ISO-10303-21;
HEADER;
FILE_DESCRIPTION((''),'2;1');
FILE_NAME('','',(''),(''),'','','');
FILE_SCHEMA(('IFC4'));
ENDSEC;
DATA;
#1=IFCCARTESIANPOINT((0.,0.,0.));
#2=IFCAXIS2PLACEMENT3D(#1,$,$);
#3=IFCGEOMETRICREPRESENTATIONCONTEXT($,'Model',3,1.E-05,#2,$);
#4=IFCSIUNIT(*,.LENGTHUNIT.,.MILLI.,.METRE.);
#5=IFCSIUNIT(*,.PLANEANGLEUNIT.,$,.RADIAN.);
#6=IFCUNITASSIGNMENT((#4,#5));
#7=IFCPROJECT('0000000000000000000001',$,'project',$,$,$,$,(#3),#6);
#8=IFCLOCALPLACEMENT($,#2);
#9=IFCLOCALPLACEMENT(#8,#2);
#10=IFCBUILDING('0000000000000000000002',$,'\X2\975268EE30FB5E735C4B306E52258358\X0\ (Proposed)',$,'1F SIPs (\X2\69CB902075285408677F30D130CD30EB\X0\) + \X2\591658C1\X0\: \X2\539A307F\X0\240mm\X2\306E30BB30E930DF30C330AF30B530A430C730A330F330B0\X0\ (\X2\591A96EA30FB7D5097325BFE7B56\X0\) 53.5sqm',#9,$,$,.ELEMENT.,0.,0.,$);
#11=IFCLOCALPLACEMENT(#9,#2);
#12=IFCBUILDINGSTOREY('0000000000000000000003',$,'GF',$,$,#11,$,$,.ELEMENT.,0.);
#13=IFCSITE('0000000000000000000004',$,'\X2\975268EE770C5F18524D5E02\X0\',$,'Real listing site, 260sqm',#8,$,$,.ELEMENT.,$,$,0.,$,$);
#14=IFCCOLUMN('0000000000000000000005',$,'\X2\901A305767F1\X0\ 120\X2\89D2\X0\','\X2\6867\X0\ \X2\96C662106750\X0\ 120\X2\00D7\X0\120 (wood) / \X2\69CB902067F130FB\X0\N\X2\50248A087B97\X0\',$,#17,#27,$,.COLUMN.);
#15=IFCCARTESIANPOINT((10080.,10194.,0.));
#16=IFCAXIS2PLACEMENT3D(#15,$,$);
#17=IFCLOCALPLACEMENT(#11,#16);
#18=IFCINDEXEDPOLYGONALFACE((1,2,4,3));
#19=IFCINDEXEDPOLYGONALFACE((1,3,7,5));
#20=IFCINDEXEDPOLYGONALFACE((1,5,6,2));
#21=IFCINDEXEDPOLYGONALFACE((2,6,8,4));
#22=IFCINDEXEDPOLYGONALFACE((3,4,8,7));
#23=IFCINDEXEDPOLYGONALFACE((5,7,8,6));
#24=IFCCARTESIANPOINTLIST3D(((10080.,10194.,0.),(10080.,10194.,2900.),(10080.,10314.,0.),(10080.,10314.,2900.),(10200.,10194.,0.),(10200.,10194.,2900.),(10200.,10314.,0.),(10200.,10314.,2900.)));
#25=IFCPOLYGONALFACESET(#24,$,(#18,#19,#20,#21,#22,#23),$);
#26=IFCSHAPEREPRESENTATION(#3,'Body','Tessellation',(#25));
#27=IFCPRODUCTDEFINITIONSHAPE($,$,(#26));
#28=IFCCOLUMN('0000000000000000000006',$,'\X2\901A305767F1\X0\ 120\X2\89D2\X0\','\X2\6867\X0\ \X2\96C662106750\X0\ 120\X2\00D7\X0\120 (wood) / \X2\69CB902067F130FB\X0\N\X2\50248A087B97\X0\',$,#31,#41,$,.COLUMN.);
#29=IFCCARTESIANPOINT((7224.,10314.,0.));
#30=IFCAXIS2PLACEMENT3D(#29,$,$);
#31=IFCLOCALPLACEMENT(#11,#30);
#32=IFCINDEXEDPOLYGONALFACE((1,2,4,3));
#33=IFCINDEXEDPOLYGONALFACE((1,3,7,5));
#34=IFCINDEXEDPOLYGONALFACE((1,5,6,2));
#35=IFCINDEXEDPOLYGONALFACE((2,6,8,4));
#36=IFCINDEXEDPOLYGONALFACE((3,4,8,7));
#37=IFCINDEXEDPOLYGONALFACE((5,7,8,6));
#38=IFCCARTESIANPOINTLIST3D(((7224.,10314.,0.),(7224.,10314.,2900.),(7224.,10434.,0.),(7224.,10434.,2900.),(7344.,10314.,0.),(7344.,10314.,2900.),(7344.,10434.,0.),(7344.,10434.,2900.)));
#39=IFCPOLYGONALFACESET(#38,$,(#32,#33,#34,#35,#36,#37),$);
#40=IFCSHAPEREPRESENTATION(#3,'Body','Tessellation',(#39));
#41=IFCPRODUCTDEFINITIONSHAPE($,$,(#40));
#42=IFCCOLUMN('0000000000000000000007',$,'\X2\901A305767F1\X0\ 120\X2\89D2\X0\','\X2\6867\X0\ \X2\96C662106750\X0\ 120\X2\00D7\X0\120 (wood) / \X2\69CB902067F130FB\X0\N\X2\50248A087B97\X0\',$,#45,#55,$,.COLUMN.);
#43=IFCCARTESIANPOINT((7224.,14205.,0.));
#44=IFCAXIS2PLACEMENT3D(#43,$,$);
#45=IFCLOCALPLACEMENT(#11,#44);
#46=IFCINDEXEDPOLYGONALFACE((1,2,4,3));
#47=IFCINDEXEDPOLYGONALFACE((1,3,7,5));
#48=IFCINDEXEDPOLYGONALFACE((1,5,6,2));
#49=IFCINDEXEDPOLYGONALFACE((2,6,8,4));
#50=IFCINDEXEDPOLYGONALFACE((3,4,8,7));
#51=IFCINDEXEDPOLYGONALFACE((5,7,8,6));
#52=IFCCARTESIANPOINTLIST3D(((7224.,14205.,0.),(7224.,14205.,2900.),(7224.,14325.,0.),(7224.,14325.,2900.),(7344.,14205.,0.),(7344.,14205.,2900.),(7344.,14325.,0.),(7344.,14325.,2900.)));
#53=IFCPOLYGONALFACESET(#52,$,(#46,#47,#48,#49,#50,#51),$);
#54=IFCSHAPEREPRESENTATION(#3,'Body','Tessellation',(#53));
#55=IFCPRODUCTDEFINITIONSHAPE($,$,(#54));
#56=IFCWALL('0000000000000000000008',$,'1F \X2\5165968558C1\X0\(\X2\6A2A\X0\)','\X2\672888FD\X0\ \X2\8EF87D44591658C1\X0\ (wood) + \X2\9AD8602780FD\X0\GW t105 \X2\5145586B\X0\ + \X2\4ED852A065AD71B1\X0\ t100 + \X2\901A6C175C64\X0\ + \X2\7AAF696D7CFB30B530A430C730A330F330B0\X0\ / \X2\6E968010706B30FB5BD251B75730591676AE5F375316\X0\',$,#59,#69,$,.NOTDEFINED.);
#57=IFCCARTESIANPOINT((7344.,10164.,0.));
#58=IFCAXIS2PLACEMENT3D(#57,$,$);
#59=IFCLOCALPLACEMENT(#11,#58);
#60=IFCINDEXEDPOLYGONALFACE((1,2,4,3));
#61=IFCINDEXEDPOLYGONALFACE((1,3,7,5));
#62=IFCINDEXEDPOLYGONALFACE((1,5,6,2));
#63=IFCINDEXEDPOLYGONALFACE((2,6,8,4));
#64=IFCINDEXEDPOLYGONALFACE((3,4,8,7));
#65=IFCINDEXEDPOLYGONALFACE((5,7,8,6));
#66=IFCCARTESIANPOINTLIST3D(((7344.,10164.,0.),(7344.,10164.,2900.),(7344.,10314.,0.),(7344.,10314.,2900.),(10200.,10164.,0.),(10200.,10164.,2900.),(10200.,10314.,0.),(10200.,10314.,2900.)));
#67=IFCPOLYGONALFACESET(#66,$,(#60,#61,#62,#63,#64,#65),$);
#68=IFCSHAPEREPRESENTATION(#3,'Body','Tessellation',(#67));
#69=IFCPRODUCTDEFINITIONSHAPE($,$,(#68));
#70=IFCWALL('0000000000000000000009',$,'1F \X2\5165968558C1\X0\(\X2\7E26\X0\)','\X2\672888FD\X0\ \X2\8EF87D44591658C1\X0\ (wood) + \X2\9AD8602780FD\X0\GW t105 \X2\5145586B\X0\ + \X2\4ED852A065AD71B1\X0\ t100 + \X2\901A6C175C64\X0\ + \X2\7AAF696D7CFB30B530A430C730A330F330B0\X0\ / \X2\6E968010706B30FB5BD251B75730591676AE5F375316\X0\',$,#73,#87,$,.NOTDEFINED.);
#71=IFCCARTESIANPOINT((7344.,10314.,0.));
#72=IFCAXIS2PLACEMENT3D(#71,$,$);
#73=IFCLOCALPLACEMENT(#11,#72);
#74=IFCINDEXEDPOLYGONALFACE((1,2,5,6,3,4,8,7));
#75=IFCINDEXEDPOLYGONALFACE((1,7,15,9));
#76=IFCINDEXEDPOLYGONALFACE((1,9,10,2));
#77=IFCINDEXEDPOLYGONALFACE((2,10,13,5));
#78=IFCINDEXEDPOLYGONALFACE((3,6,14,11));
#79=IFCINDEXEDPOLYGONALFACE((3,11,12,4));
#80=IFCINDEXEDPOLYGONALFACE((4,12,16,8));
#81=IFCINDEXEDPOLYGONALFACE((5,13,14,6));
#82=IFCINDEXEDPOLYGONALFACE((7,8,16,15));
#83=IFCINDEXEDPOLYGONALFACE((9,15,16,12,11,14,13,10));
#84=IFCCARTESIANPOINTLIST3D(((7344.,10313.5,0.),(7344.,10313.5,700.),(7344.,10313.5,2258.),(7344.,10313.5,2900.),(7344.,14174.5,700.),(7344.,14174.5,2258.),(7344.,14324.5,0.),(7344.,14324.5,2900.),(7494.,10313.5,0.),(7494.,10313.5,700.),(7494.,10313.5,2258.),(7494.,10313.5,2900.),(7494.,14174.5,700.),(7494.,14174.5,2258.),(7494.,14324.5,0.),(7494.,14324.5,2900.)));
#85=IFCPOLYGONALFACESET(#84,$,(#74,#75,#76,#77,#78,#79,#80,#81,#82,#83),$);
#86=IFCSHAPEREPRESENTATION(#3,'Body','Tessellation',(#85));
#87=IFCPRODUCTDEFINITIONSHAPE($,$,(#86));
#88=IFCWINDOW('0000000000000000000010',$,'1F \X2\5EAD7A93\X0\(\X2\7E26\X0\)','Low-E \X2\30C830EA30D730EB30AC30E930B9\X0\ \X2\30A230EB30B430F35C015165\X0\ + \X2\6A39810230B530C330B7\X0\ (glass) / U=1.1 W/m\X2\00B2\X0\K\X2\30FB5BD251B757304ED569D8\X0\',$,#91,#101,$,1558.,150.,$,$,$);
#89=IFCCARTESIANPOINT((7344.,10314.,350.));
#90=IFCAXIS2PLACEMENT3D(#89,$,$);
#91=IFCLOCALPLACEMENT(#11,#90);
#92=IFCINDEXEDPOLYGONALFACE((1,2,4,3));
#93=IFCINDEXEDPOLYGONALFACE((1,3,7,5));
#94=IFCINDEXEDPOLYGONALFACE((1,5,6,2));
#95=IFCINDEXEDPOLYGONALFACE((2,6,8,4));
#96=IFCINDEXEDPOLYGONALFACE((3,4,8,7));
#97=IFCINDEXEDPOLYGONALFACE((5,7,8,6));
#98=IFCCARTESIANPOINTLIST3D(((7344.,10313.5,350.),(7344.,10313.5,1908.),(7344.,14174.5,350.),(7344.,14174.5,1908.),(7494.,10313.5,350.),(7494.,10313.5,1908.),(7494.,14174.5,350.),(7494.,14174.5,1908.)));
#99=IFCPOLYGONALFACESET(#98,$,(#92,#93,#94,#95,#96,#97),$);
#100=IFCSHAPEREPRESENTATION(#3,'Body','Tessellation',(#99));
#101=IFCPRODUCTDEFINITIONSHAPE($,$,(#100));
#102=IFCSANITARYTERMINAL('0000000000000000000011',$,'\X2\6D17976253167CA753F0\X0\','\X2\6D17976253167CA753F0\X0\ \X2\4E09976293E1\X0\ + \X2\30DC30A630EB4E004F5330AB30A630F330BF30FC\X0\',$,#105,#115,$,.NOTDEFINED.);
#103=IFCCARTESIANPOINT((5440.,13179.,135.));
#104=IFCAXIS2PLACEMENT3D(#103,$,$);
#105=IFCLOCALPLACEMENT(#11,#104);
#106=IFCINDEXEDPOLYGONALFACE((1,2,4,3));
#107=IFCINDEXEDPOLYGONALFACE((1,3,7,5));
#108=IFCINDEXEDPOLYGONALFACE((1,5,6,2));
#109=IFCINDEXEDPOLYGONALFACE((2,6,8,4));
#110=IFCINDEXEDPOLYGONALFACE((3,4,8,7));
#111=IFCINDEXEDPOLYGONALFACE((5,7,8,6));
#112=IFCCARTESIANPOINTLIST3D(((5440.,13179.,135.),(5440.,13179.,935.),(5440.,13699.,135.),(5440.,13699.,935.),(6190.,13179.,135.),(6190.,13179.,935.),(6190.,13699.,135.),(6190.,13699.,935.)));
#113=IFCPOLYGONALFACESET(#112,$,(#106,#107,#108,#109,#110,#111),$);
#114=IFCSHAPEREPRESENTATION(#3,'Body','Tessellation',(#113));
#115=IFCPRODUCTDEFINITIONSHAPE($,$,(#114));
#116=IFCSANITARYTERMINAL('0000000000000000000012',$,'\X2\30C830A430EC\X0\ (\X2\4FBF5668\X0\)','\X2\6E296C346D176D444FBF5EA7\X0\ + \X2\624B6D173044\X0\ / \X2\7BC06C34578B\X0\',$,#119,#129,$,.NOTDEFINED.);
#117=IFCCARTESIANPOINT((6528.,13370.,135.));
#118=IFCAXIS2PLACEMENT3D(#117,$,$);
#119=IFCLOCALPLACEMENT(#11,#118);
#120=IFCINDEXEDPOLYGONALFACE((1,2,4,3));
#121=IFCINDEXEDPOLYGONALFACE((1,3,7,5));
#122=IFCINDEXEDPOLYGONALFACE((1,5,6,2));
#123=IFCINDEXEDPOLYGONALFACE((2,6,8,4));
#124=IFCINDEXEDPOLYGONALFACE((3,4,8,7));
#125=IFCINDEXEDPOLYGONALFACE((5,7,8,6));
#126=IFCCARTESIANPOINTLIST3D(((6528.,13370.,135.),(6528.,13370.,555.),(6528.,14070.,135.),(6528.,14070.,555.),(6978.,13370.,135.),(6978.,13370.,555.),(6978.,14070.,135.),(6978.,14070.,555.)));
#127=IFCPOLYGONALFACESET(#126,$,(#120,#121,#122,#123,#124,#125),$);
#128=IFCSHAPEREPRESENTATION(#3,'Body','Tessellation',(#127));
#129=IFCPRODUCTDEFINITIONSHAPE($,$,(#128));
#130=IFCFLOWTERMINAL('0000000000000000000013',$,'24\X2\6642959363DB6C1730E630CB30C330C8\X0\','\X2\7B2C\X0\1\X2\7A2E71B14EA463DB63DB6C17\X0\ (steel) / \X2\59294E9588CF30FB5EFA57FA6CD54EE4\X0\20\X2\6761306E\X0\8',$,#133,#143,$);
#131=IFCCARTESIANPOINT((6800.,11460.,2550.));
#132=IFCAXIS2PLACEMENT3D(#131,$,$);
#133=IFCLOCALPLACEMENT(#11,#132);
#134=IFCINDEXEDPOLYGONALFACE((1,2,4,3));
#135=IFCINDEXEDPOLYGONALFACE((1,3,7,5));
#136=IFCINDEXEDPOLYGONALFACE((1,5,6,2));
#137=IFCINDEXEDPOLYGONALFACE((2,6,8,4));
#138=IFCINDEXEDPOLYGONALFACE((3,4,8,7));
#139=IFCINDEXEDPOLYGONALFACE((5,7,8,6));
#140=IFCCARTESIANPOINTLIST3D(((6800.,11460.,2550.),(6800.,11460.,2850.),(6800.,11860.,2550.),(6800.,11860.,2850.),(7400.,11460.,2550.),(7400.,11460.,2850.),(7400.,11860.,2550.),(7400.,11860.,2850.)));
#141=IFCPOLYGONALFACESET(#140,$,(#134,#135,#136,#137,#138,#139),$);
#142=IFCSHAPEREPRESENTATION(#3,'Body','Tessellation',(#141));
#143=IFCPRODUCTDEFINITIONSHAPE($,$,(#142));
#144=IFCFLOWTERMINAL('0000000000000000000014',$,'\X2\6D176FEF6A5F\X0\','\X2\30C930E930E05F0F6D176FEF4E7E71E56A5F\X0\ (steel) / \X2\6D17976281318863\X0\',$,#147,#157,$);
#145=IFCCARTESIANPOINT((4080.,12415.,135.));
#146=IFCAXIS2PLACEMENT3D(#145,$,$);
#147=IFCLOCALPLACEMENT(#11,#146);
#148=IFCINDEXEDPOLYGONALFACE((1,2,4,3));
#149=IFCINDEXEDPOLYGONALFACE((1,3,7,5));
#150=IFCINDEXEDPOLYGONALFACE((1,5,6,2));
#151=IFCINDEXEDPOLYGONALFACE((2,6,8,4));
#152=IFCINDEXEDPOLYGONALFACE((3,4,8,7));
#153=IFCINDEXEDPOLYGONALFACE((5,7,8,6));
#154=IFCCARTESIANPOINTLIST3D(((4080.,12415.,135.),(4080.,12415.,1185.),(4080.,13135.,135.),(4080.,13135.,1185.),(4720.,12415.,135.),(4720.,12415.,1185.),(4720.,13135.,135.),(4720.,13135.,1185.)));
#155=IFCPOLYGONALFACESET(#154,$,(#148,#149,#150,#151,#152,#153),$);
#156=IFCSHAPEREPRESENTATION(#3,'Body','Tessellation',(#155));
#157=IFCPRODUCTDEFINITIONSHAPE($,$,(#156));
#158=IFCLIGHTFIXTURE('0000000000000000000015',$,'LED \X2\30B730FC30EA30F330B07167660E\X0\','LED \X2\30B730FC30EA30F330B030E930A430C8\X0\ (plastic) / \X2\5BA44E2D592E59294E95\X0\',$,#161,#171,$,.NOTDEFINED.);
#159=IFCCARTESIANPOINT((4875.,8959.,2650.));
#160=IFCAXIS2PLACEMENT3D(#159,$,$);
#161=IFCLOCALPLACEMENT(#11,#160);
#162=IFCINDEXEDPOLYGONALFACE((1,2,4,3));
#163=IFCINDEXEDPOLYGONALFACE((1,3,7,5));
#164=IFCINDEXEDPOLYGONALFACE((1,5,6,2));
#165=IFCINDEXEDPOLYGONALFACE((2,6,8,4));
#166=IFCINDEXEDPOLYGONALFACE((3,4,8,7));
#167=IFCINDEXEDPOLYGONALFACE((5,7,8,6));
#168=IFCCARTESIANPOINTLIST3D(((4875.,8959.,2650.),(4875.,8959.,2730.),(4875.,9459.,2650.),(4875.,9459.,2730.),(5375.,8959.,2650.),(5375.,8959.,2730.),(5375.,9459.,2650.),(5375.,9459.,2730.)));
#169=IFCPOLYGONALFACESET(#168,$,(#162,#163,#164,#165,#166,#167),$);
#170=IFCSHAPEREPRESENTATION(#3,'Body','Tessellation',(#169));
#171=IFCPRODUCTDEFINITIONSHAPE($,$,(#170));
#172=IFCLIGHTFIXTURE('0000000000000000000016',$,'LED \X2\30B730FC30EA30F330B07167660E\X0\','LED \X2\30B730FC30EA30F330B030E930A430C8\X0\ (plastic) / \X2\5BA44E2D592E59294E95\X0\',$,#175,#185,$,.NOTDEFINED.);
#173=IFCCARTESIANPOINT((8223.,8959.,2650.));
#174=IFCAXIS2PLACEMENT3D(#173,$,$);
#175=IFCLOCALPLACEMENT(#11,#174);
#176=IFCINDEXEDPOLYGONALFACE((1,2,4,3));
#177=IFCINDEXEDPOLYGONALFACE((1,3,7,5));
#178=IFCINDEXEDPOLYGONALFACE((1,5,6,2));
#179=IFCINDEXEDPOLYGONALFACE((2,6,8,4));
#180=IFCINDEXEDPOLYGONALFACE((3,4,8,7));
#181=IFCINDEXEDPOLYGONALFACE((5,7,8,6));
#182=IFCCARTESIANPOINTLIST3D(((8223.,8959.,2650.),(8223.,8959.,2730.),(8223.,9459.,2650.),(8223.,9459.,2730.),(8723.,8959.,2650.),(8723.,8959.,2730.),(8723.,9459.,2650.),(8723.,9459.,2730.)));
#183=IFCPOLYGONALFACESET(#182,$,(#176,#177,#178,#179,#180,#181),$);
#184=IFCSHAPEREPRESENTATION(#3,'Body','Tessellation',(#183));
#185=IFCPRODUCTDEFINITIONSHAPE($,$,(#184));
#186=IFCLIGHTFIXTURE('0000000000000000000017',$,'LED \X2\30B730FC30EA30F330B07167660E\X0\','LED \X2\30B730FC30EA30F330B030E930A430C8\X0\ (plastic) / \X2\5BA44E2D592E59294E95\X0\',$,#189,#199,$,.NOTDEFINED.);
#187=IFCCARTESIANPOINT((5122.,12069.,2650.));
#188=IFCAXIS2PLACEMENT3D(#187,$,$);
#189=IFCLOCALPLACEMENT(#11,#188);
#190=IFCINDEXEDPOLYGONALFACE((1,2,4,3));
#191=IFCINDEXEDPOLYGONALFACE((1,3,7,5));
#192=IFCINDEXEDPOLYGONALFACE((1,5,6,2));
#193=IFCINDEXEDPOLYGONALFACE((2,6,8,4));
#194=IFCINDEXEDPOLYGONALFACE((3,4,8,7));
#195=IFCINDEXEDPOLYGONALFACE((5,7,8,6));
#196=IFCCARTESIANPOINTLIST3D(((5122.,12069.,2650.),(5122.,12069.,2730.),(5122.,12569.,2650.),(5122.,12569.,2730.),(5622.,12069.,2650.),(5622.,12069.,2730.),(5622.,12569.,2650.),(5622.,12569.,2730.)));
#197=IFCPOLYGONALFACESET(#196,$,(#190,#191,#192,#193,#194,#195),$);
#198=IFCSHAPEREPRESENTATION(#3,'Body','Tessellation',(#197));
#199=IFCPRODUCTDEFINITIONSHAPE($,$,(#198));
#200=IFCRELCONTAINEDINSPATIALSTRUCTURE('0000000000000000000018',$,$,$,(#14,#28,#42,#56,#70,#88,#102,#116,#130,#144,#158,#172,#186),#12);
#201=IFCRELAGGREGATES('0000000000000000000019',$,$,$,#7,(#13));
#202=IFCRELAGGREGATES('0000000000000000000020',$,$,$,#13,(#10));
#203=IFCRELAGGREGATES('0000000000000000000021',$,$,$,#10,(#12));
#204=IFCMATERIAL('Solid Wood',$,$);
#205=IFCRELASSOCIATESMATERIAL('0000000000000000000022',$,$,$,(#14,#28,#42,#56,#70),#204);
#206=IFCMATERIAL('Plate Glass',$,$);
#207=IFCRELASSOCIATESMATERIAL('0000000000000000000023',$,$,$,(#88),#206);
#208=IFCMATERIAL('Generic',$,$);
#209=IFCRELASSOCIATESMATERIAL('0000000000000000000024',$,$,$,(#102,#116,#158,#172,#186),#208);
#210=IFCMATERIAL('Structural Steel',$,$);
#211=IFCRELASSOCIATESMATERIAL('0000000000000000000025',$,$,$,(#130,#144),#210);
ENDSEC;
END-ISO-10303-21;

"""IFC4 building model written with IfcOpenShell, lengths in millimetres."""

from ifc_helpers import new_model, si_unit, frame, frame_2d, origin, place, context, project, spatial, rectangle, extrude, material, element, fill, save


model = new_model("IFC4")

# Units and contexts
model_context = context("Model", 3, precision=1e-05, world=origin())
ifc_project = project(units=[si_unit("LENGTHUNIT", "METRE", prefix="MILLI"), si_unit("PLANEANGLEUNIT", "RADIAN")], contexts=[model_context])

# Site, building, storey
site_placement = place(None, origin())
site = spatial("IfcSite", under=ifc_project, at=site_placement, Name="青森県弘前市", ObjectType="Real listing site, 260sqm", CompositionType="ELEMENT", RefElevation=0.0)
building_placement = place(site_placement, origin())
building = spatial("IfcBuilding", under=site, at=building_placement, Name="青森・平屋の別荘 (Proposed)", ObjectType="1F SIPs (構造用合板パネル) + 外壁: 厚み240mmのセラミックサイディング (多雪・結露対策) 53.5sqm", CompositionType="ELEMENT", ElevationOfRefHeight=0.0, ElevationOfTerrain=0.0)
storey_placement = place(building_placement, origin())
storey = spatial("IfcBuildingStorey", under=building, at=storey_placement, Name="GF", CompositionType="ELEMENT", Elevation=0.0)

# Columns
ifc_material_1 = material(Name="Solid Wood")
column_1_placement = place(storey_placement, frame((10080.0, 10194.0, 0.0)))
element("IfcColumn", 1, at=column_1_placement, inside=storey, material=ifc_material_1, Name="通し柱 120角", Description="桧 集成材 120×120 (wood) / 構造柱・N値計算", PredefinedType="COLUMN", context=model_context, shape_type="SweptSolid", body=[
    extrude(rectangle(XDim=120.0, YDim=120.0, at=frame_2d((60.0, 60.0))), frame((10080.0, 10194.0, 0.0)), (0.0, 0.0, 1.0), 2900.0),
])
column_2_placement = place(storey_placement, frame((7224.0, 10314.0, 0.0)))
element("IfcColumn", 2, at=column_2_placement, inside=storey, material=ifc_material_1, Name="通し柱 120角", Description="桧 集成材 120×120 (wood) / 構造柱・N値計算", PredefinedType="COLUMN", context=model_context, shape_type="SweptSolid", body=[
    extrude(rectangle(XDim=120.0, YDim=120.0, at=frame_2d((60.0, 60.0))), frame((7224.0, 10314.0, 0.0)), (0.0, 0.0, 1.0), 2900.0),
])
column_3_placement = place(storey_placement, frame((7224.0, 14205.0, 0.0)))
element("IfcColumn", 3, at=column_3_placement, inside=storey, material=ifc_material_1, Name="通し柱 120角", Description="桧 集成材 120×120 (wood) / 構造柱・N値計算", PredefinedType="COLUMN", context=model_context, shape_type="SweptSolid", body=[
    extrude(rectangle(XDim=120.0, YDim=120.0, at=frame_2d((60.0, 60.0))), frame((7224.0, 14205.0, 0.0)), (0.0, 0.0, 1.0), 2900.0),
])

# Wall
wall_1_placement = place(storey_placement, frame((7344.0, 10164.0, 0.0)))
element("IfcWall", 4, at=wall_1_placement, inside=storey, material=ifc_material_1, Name="1F 入隅壁(横)", Description="木製 軸組外壁 (wood) + 高性能GW t105 充填 + 付加断熱 t100 + 通気層 + 窯業系サイディング / 準耐火・寒冷地外皮強化", PredefinedType="NOTDEFINED", context=model_context, shape_type="SweptSolid", body=[
    extrude(rectangle(XDim=2856.0, YDim=150.0, at=frame_2d((1428.0, 75.0))), frame((7344.0, 10164.0, 0.0)), (0.0, 0.0, 1.0), 2900.0),
])

# Wall, opening, window
wall_2_placement = place(storey_placement, frame((7344.0, 10314.0, 0.0)))
wall_2 = element("IfcWall", 5, at=wall_2_placement, inside=storey, material=ifc_material_1, Name="1F 入隅壁(縦)", Description="木製 軸組外壁 (wood) + 高性能GW t105 充填 + 付加断熱 t100 + 通気層 + 窯業系サイディング / 準耐火・寒冷地外皮強化", PredefinedType="NOTDEFINED", context=model_context, shape_type="SweptSolid", body=[
    extrude(rectangle(XDim=150.0, YDim=4011.0, at=frame_2d((75.0, 2005.0))), frame((7344.0, 10314.0, 0.0)), (0.0, 0.0, 1.0), 2900.0),
])
opening_placement = place(storey_placement, frame((7344.0, 10314.0, 350.0)))
opening = element("IfcOpeningElement", 6, at=opening_placement, cuts=wall_2, PredefinedType="NOTDEFINED", context=model_context, shape_type="SweptSolid", body=[
    extrude(rectangle(XDim=150.0, YDim=3861.0, at=frame_2d((75.0, 1930.0))), frame((7344.0, 10314.0, 350.0)), (0.0, 0.0, 1.0), 1558.0),
])
ifc_material_2 = material(Name="Plate Glass")
window_placement = place(storey_placement, frame((7344.0, 10314.0, 350.0)))
window = element("IfcWindow", 7, at=window_placement, inside=storey, material=ifc_material_2, Name="1F 庭窓(縦)", Description="Low-E トリプルガラス アルゴン封入 + 樹脂サッシ (glass) / U=1.1 W/m²K・寒冷地仕様", OverallHeight=1558.0, OverallWidth=150.0, context=model_context, shape_type="SweptSolid", body=[
    extrude(rectangle(XDim=150.0, YDim=3861.0, at=frame_2d((75.0, 1930.0))), frame((7344.0, 10314.0, 350.0)), (0.0, 0.0, 1.0), 1558.0),
])
fill(opening, window)

# Sanitary terminals
ifc_material_3 = material(Name="Generic")
sanitary_terminal_1_placement = place(storey_placement, frame((5440.0, 13179.0, 135.0)))
element("IfcSanitaryTerminal", 8, at=sanitary_terminal_1_placement, inside=storey, material=ifc_material_3, Name="洗面化粧台", Description="洗面化粧台 三面鏡 + ボウル一体カウンター", PredefinedType="NOTDEFINED", context=model_context, shape_type="SweptSolid", body=[
    extrude(rectangle(XDim=750.0, YDim=520.0, at=frame_2d((375.0, 260.0))), frame((5440.0, 13179.0, 135.0)), (0.0, 0.0, 1.0), 800.0),
])
sanitary_terminal_2_placement = place(storey_placement, frame((6528.0, 13370.0, 135.0)))
element("IfcSanitaryTerminal", 9, at=sanitary_terminal_2_placement, inside=storey, material=ifc_material_3, Name="トイレ (便器)", Description="温水洗浄便座 + 手洗い / 節水型", PredefinedType="NOTDEFINED", context=model_context, shape_type="SweptSolid", body=[
    extrude(rectangle(XDim=450.0, YDim=700.0, at=frame_2d((225.0, 350.0))), frame((6528.0, 13370.0, 135.0)), (0.0, 0.0, 1.0), 420.0),
])

# Flow terminals
ifc_material_4 = material(Name="Structural Steel")
flow_terminal_1_placement = place(storey_placement, frame((6800.0, 11460.0, 2550.0)))
element("IfcFlowTerminal", 10, at=flow_terminal_1_placement, inside=storey, material=ifc_material_4, Name="24時間換気ユニット", Description="第1種熱交換換気 (steel) / 天井裏・建基法令20条の8", context=model_context, shape_type="SweptSolid", body=[
    extrude(rectangle(XDim=600.0, YDim=400.0, at=frame_2d((300.0, 200.0))), frame((6800.0, 11460.0, 2550.0)), (0.0, 0.0, 1.0), 300.0),
])
flow_terminal_2_placement = place(storey_placement, frame((4080.0, 12415.0, 135.0)))
element("IfcFlowTerminal", 11, at=flow_terminal_2_placement, inside=storey, material=ifc_material_4, Name="洗濯機", Description="ドラム式洗濯乾燥機 (steel) / 洗面脱衣", context=model_context, shape_type="SweptSolid", body=[
    extrude(rectangle(XDim=640.0, YDim=720.0, at=frame_2d((320.0, 360.0))), frame((4080.0, 12415.0, 135.0)), (0.0, 0.0, 1.0), 1050.0),
])

# Light fixtures
light_fixture_1_placement = place(storey_placement, frame((4875.0, 8959.0, 2650.0)))
element("IfcLightFixture", 12, at=light_fixture_1_placement, inside=storey, material=ifc_material_3, Name="LED シーリング照明", Description="LED シーリングライト (plastic) / 室中央天井", PredefinedType="NOTDEFINED", context=model_context, shape_type="SweptSolid", body=[
    extrude(rectangle(XDim=500.0, YDim=500.0, at=frame_2d((250.0, 250.0))), frame((4875.0, 8959.0, 2650.0)), (0.0, 0.0, 1.0), 80.0),
])
light_fixture_2_placement = place(storey_placement, frame((8223.0, 8959.0, 2650.0)))
element("IfcLightFixture", 13, at=light_fixture_2_placement, inside=storey, material=ifc_material_3, Name="LED シーリング照明", Description="LED シーリングライト (plastic) / 室中央天井", PredefinedType="NOTDEFINED", context=model_context, shape_type="SweptSolid", body=[
    extrude(rectangle(XDim=500.0, YDim=500.0, at=frame_2d((250.0, 250.0))), frame((8223.0, 8959.0, 2650.0)), (0.0, 0.0, 1.0), 80.0),
])
light_fixture_3_placement = place(storey_placement, frame((5122.0, 12069.0, 2650.0)))
element("IfcLightFixture", 14, at=light_fixture_3_placement, inside=storey, material=ifc_material_3, Name="LED シーリング照明", Description="LED シーリングライト (plastic) / 室中央天井", PredefinedType="NOTDEFINED", context=model_context, shape_type="SweptSolid", body=[
    extrude(rectangle(XDim=500.0, YDim=500.0, at=frame_2d((250.0, 250.0))), frame((5122.0, 12069.0, 2650.0)), (0.0, 0.0, 1.0), 80.0),
])

save(model, "model.ifc")
